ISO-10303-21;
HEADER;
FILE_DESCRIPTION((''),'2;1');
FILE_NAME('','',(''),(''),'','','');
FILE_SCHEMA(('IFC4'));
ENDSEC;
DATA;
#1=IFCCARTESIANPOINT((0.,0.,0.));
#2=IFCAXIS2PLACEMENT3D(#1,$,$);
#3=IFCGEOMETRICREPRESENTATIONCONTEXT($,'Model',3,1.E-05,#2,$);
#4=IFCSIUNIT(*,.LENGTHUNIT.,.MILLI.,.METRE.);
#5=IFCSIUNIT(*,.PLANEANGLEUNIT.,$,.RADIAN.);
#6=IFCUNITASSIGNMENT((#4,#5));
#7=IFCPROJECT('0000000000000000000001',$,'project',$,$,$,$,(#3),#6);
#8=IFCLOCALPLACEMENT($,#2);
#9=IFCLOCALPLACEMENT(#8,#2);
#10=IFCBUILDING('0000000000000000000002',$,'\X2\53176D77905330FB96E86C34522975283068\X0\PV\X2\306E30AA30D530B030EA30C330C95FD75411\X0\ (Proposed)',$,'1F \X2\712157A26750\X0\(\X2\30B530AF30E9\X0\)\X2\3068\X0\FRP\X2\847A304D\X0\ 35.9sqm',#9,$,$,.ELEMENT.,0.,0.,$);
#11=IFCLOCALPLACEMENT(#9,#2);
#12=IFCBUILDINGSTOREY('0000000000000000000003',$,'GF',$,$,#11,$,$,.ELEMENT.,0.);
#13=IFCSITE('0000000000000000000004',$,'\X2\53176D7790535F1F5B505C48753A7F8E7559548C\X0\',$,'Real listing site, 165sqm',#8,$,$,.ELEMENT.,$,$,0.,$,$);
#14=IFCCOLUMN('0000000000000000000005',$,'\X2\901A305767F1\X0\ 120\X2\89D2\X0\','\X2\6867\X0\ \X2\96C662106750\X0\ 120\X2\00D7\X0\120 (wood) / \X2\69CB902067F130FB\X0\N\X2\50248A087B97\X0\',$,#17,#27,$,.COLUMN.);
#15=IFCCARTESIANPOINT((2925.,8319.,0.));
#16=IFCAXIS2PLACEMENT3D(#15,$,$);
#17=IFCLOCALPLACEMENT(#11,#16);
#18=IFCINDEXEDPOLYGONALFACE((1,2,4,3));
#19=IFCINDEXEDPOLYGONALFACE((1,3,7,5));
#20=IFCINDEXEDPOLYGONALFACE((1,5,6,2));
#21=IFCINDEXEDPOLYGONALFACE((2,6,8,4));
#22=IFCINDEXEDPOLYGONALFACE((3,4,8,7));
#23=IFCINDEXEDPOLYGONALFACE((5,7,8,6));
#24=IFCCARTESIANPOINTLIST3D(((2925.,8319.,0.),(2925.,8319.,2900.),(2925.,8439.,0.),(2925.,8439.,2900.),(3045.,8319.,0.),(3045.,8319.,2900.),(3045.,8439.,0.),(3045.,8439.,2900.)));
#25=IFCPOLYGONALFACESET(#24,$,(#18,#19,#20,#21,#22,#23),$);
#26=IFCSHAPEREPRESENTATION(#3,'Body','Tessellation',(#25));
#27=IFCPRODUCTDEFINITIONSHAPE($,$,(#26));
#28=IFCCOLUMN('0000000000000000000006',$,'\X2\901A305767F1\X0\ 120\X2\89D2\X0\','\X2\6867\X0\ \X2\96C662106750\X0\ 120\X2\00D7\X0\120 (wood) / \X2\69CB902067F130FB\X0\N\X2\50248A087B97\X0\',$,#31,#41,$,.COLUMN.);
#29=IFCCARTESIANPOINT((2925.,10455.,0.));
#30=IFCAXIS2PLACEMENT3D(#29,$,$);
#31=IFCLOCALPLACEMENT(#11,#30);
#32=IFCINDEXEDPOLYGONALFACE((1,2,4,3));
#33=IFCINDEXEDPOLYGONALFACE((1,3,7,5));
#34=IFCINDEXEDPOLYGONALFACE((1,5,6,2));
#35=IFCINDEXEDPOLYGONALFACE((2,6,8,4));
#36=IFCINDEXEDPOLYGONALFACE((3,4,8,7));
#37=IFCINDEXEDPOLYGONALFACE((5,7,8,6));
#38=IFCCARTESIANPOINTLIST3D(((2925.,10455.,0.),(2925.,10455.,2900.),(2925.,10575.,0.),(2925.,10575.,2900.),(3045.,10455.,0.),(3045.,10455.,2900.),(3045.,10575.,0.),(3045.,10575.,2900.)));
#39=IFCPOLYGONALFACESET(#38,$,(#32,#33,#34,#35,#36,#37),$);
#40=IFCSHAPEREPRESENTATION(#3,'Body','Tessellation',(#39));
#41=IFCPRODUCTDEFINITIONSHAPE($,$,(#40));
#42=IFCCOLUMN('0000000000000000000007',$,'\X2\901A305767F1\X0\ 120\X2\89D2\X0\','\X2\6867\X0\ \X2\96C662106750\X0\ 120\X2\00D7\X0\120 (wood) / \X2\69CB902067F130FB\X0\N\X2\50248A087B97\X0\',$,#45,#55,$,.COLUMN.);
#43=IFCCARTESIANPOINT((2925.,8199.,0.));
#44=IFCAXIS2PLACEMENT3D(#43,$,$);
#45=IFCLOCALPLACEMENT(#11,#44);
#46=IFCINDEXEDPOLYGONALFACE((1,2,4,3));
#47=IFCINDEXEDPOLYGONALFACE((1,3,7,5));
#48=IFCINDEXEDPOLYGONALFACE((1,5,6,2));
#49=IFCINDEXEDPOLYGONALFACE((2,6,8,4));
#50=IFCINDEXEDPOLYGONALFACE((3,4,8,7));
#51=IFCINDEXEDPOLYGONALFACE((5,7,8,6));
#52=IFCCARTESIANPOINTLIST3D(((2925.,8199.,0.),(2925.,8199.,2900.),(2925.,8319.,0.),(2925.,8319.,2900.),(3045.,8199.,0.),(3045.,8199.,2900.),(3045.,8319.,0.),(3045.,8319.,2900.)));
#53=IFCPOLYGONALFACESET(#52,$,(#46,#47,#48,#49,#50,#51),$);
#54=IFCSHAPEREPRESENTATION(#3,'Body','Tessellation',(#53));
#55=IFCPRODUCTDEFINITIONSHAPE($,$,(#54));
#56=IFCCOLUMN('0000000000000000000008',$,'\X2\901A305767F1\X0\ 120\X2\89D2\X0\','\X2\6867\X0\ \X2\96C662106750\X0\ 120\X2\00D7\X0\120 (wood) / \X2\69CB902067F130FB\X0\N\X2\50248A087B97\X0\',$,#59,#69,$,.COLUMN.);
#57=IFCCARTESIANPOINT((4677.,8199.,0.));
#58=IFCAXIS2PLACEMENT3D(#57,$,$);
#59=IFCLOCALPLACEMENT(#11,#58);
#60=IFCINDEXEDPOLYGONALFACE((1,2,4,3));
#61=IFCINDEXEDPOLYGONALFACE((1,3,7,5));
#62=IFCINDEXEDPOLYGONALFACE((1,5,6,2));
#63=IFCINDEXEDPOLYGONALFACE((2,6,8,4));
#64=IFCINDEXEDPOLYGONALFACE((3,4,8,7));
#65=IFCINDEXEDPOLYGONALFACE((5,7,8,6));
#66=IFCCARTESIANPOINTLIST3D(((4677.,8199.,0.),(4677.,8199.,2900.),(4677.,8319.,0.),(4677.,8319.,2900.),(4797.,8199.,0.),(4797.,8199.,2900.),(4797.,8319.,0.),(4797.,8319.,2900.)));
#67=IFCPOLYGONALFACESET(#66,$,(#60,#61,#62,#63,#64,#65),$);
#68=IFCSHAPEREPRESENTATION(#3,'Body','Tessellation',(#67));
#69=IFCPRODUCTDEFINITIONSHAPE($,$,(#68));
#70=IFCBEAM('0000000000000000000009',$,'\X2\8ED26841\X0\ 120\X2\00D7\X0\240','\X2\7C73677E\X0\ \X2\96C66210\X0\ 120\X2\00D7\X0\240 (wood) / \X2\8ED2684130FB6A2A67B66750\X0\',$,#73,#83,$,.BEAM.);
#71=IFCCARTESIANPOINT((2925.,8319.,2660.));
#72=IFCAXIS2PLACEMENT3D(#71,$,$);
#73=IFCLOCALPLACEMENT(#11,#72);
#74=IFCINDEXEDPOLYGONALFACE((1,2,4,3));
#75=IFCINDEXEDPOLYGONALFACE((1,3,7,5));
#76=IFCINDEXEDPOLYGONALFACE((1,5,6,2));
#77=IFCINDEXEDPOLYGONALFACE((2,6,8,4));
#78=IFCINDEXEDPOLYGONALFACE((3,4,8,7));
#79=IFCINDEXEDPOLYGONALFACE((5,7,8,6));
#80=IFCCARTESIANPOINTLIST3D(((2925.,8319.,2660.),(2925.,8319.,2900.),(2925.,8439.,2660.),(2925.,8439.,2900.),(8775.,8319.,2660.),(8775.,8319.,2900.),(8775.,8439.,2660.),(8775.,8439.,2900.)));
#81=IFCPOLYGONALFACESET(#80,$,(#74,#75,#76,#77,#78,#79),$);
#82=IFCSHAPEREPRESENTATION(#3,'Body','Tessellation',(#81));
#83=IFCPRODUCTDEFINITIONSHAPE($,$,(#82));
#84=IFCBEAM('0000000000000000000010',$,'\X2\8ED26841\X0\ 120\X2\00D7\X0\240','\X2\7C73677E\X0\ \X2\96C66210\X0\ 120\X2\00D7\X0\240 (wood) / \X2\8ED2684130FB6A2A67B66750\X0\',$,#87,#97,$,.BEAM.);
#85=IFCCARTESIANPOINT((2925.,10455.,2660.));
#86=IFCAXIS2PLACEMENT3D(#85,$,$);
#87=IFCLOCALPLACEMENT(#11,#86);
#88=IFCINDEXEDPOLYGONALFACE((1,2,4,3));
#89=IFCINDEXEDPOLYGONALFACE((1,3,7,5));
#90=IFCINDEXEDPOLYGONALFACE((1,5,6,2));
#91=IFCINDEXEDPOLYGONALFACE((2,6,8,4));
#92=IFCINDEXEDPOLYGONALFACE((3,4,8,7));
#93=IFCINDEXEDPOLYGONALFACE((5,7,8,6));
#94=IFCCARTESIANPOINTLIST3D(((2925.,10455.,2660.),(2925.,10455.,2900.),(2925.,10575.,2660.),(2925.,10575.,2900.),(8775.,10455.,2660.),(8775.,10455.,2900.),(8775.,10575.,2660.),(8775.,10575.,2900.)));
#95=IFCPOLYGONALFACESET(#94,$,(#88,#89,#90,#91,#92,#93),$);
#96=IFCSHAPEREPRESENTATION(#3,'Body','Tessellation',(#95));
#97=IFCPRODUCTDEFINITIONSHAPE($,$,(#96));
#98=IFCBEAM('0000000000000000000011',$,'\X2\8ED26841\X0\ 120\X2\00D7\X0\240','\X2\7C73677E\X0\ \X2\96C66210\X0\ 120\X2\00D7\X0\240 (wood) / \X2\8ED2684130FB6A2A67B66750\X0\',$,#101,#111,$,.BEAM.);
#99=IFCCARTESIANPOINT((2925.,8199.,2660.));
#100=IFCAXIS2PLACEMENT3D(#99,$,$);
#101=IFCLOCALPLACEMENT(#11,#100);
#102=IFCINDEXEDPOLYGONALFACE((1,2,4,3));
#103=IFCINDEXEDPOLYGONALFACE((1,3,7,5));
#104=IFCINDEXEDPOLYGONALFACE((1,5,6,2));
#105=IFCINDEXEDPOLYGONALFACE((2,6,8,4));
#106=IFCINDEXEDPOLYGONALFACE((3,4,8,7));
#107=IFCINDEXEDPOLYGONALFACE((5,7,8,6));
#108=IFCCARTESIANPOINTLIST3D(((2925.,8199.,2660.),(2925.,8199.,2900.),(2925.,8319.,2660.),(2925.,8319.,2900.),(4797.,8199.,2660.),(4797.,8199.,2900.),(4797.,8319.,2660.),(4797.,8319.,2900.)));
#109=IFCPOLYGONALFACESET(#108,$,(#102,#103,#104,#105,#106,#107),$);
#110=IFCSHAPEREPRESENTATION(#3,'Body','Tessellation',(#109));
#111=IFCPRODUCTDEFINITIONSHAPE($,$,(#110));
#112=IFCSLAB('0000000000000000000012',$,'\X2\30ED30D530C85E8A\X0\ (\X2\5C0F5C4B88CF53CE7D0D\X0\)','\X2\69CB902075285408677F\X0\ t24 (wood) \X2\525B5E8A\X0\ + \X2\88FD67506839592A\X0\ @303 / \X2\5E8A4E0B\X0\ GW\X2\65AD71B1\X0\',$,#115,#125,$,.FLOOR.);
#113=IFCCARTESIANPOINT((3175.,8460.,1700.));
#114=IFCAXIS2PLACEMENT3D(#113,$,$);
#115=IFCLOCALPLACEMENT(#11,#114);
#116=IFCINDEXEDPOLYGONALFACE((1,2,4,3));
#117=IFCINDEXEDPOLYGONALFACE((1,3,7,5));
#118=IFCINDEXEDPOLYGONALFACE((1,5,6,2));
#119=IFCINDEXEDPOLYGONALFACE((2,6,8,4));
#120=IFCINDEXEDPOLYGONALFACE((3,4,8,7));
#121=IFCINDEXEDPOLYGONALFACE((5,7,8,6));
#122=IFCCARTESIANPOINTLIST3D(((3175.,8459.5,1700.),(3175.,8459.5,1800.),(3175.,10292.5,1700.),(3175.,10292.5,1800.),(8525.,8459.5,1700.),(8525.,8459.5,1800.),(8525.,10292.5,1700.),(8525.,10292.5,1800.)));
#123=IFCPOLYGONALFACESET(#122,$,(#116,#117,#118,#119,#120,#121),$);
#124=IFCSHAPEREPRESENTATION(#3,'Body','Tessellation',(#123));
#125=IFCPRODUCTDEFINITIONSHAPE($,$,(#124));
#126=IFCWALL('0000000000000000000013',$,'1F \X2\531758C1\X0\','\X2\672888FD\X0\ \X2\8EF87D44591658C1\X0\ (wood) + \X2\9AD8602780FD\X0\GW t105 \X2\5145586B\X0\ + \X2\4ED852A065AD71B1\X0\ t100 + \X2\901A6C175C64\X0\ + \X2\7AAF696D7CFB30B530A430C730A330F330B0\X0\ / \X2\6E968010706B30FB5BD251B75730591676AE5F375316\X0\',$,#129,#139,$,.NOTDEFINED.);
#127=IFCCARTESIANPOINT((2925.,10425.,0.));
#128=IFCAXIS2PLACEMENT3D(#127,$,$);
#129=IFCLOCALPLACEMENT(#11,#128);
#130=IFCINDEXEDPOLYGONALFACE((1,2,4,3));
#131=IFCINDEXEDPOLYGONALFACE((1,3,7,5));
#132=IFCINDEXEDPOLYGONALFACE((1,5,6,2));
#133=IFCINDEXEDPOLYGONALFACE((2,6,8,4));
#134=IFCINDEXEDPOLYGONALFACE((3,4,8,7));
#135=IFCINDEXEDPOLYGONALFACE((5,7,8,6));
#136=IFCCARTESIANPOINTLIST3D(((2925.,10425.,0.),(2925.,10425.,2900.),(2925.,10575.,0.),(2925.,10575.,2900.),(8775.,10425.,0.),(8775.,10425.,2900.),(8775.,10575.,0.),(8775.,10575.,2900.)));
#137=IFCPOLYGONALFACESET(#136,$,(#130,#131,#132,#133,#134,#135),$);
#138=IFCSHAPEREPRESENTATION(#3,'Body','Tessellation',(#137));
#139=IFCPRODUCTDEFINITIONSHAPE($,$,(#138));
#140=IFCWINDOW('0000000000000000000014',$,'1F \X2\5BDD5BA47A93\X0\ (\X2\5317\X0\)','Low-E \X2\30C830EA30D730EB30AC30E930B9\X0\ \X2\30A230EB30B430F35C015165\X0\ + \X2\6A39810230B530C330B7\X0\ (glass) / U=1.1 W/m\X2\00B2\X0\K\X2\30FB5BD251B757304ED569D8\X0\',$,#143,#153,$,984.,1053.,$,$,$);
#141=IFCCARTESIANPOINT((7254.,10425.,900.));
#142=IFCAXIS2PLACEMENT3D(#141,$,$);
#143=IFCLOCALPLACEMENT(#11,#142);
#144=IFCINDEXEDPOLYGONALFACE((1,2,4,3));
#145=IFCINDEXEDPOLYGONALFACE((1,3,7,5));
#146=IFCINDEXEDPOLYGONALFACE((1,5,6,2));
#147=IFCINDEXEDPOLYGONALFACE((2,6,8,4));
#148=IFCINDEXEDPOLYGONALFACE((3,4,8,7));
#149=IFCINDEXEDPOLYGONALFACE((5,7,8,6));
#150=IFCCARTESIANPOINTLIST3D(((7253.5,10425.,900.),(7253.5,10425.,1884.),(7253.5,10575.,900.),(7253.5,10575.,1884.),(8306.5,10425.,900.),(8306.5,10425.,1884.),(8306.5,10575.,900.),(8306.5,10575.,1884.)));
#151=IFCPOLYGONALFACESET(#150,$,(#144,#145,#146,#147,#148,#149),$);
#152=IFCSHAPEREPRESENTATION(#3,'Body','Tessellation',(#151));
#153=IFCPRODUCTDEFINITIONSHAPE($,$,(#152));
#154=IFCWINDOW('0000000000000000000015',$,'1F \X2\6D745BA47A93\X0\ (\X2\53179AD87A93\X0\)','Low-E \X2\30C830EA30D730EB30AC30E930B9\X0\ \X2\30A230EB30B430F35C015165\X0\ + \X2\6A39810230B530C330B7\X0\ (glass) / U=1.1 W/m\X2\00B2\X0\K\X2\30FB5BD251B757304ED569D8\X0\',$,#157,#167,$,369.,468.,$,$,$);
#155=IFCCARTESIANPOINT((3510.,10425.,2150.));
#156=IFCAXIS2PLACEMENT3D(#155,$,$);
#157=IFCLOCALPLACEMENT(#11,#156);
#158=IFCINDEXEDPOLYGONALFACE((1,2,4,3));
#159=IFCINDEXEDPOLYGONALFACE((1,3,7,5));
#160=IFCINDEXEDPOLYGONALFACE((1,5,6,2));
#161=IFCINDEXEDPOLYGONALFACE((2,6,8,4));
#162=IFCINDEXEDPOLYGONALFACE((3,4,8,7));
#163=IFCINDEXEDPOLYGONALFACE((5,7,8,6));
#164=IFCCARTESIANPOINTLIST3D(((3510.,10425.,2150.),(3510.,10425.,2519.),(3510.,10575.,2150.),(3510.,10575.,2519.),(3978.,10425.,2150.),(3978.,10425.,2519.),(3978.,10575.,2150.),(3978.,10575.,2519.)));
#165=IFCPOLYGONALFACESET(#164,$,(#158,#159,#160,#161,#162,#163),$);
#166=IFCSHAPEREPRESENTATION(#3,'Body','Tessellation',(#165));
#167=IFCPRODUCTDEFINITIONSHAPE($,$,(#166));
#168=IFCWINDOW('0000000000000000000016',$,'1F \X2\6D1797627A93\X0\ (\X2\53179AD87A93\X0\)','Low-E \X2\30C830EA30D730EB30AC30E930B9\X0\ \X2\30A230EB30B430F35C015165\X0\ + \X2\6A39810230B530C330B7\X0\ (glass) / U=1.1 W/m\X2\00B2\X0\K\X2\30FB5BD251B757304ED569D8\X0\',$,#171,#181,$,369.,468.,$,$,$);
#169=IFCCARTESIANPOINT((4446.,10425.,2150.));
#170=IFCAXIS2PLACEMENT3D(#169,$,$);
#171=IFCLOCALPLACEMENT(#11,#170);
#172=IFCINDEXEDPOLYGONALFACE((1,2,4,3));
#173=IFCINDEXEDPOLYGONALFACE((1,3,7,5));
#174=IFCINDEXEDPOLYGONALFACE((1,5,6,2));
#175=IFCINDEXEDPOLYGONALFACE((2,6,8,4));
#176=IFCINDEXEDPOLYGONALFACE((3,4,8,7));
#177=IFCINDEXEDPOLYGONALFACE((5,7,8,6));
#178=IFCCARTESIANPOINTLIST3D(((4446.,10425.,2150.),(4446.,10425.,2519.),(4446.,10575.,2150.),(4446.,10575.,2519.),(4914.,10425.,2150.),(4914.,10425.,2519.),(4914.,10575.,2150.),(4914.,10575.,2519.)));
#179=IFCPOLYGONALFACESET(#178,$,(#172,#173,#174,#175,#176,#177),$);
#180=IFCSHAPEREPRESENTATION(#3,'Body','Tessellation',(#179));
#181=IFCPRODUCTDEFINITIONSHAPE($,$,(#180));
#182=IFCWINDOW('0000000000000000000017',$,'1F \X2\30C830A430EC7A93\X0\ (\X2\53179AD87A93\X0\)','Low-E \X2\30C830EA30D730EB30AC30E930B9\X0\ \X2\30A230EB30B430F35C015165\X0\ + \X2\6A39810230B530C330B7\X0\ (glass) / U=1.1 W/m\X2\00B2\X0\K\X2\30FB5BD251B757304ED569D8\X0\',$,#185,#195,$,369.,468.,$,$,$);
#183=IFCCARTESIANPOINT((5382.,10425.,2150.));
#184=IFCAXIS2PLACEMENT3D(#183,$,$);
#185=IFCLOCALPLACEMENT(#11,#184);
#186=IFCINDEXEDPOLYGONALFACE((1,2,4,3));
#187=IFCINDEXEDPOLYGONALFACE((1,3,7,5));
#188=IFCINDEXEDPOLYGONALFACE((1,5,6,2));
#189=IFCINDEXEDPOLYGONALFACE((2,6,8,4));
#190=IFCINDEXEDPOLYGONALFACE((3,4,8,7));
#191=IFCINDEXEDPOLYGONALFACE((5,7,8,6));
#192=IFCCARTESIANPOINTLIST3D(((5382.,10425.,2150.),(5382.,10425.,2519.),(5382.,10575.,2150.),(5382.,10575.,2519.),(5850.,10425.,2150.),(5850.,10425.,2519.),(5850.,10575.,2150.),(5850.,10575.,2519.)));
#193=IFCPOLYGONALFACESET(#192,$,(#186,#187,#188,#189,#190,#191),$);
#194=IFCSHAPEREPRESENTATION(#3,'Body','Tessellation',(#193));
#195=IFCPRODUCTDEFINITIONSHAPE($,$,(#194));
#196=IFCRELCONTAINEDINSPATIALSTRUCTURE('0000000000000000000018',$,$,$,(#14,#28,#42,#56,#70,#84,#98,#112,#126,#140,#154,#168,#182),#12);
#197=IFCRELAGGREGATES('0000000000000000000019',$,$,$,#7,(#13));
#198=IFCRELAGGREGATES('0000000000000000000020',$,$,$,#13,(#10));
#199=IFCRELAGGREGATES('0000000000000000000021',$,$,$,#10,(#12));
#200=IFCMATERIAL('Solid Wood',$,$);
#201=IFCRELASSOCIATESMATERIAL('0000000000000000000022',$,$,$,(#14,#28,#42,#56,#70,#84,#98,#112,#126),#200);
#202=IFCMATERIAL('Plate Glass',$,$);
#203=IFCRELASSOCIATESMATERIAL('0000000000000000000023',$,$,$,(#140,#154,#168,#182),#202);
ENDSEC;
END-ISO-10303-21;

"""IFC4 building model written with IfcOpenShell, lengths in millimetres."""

from ifc_helpers import new_model, si_unit, frame, frame_2d, origin, place, context, project, spatial, rectangle, extrude, material, element, fill, save


model = new_model("IFC4")

# Units and contexts
model_context = context("Model", 3, precision=1e-05, world=origin())
ifc_project = project(units=[si_unit("LENGTHUNIT", "METRE", prefix="MILLI"), si_unit("PLANEANGLEUNIT", "RADIAN")], contexts=[model_context])

# Site, building, storey
site_placement = place(None, origin())
site = spatial("IfcSite", under=ifc_project, at=site_placement, Name="北海道弟子屈町美留和", ObjectType="Real listing site, 165sqm", CompositionType="ELEMENT", RefElevation=0.0)
building_placement = place(site_placement, origin())
building = spatial("IfcBuilding", under=site, at=building_placement, Name="北海道・雨水利用とPVのオフグリッド志向 (Proposed)", ObjectType="1F 無垢材(サクラ)とFRP葺き 35.9sqm", CompositionType="ELEMENT", ElevationOfRefHeight=0.0, ElevationOfTerrain=0.0)
storey_placement = place(building_placement, origin())
storey = spatial("IfcBuildingStorey", under=building, at=storey_placement, Name="GF", CompositionType="ELEMENT", Elevation=0.0)

# Columns
ifc_material_1 = material(Name="Solid Wood")
column_1_placement = place(storey_placement, frame((2925.0, 8319.0, 0.0)))
element("IfcColumn", 1, at=column_1_placement, inside=storey, material=ifc_material_1, Name="通し柱 120角", Description="桧 集成材 120×120 (wood) / 構造柱・N値計算", PredefinedType="COLUMN", context=model_context, shape_type="SweptSolid", body=[
    extrude(rectangle(XDim=120.0, YDim=120.0, at=frame_2d((60.0, 60.0))), frame((2925.0, 8319.0, 0.0)), (0.0, 0.0, 1.0), 2900.0),
])
column_2_placement = place(storey_placement, frame((2925.0, 10455.0, 0.0)))
element("IfcColumn", 2, at=column_2_placement, inside=storey, material=ifc_material_1, Name="通し柱 120角", Description="桧 集成材 120×120 (wood) / 構造柱・N値計算", PredefinedType="COLUMN", context=model_context, shape_type="SweptSolid", body=[
    extrude(rectangle(XDim=120.0, YDim=120.0, at=frame_2d((60.0, 60.0))), frame((2925.0, 10455.0, 0.0)), (0.0, 0.0, 1.0), 2900.0),
])
column_3_placement = place(storey_placement, frame((2925.0, 8199.0, 0.0)))
element("IfcColumn", 3, at=column_3_placement, inside=storey, material=ifc_material_1, Name="通し柱 120角", Description="桧 集成材 120×120 (wood) / 構造柱・N値計算", PredefinedType="COLUMN", context=model_context, shape_type="SweptSolid", body=[
    extrude(rectangle(XDim=120.0, YDim=120.0, at=frame_2d((60.0, 60.0))), frame((2925.0, 8199.0, 0.0)), (0.0, 0.0, 1.0), 2900.0),
])
column_4_placement = place(storey_placement, frame((4677.0, 8199.0, 0.0)))
element("IfcColumn", 4, at=column_4_placement, inside=storey, material=ifc_material_1, Name="通し柱 120角", Description="桧 集成材 120×120 (wood) / 構造柱・N値計算", PredefinedType="COLUMN", context=model_context, shape_type="SweptSolid", body=[
    extrude(rectangle(XDim=120.0, YDim=120.0, at=frame_2d((60.0, 60.0))), frame((4677.0, 8199.0, 0.0)), (0.0, 0.0, 1.0), 2900.0),
])

# Beams
beam_1_placement = place(storey_placement, frame((2925.0, 8319.0, 2660.0)))
element("IfcBeam", 5, at=beam_1_placement, inside=storey, material=ifc_material_1, Name="軒桁 120×240", Description="米松 集成 120×240 (wood) / 軒桁・横架材", PredefinedType="BEAM", context=model_context, shape_type="SweptSolid", body=[
    extrude(rectangle(XDim=5850.0, YDim=120.0, at=frame_2d((2925.0, 60.0))), frame((2925.0, 8319.0, 2660.0)), (0.0, 0.0, 1.0), 240.0),
])
beam_2_placement = place(storey_placement, frame((2925.0, 10455.0, 2660.0)))
element("IfcBeam", 6, at=beam_2_placement, inside=storey, material=ifc_material_1, Name="軒桁 120×240", Description="米松 集成 120×240 (wood) / 軒桁・横架材", PredefinedType="BEAM", context=model_context, shape_type="SweptSolid", body=[
    extrude(rectangle(XDim=5850.0, YDim=120.0, at=frame_2d((2925.0, 60.0))), frame((2925.0, 10455.0, 2660.0)), (0.0, 0.0, 1.0), 240.0),
])
beam_3_placement = place(storey_placement, frame((2925.0, 8199.0, 2660.0)))
element("IfcBeam", 7, at=beam_3_placement, inside=storey, material=ifc_material_1, Name="軒桁 120×240", Description="米松 集成 120×240 (wood) / 軒桁・横架材", PredefinedType="BEAM", context=model_context, shape_type="SweptSolid", body=[
    extrude(rectangle(XDim=1872.0, YDim=120.0, at=frame_2d((936.0, 60.0))), frame((2925.0, 8199.0, 2660.0)), (0.0, 0.0, 1.0), 240.0),
])

# Slab
slab_1_placement = place(storey_placement, frame((3175.0, 8460.0, 1700.0)))
element("IfcSlab", 8, at=slab_1_placement, inside=storey, material=ifc_material_1, Name="ロフト床 (小屋裏収納)", Description="構造用合板 t24 (wood) 剛床 + 製材根太 @303 / 床下 GW断熱", PredefinedType="FLOOR", context=model_context, shape_type="SweptSolid", body=[
    extrude(rectangle(XDim=5350.0, YDim=1833.0, at=frame_2d((2675.0, 916.0))), frame((3175.0, 8460.0, 1700.0)), (0.0, 0.0, 1.0), 100.0),
])

# Wall, openings, windows
wall_1_placement = place(storey_placement, frame((2925.0, 10425.0, 0.0)))
wall_1 = element("IfcWall", 9, at=wall_1_placement, inside=storey, material=ifc_material_1, Name="1F 北壁", Description="木製 軸組外壁 (wood) + 高性能GW t105 充填 + 付加断熱 t100 + 通気層 + 窯業系サイディング / 準耐火・寒冷地外皮強化", PredefinedType="NOTDEFINED", context=model_context, shape_type="SweptSolid", body=[
    extrude(rectangle(XDim=5850.0, YDim=150.0, at=frame_2d((2925.0, 75.0))), frame((2925.0, 10425.0, 0.0)), (0.0, 0.0, 1.0), 2900.0),
])
opening_1_placement = place(storey_placement, frame((7254.0, 10425.0, 900.0)))
opening_1 = element("IfcOpeningElement", 10, at=opening_1_placement, cuts=wall_1, PredefinedType="NOTDEFINED", context=model_context, shape_type="SweptSolid", body=[
    extrude(rectangle(XDim=1053.0, YDim=150.0, at=frame_2d((526.0, 75.0))), frame((7254.0, 10425.0, 900.0)), (0.0, 0.0, 1.0), 984.0),
])
opening_2_placement = place(storey_placement, frame((3510.0, 10425.0, 2150.0)))
opening_2 = element("IfcOpeningElement", 11, at=opening_2_placement, cuts=wall_1, PredefinedType="NOTDEFINED", context=model_context, shape_type="SweptSolid", body=[
    extrude(rectangle(XDim=468.0, YDim=150.0, at=frame_2d((234.0, 75.0))), frame((3510.0, 10425.0, 2150.0)), (0.0, 0.0, 1.0), 369.0),
])
opening_3_placement = place(storey_placement, frame((4446.0, 10425.0, 2150.0)))
opening_3 = element("IfcOpeningElement", 12, at=opening_3_placement, cuts=wall_1, PredefinedType="NOTDEFINED", context=model_context, shape_type="SweptSolid", body=[
    extrude(rectangle(XDim=468.0, YDim=150.0, at=frame_2d((234.0, 75.0))), frame((4446.0, 10425.0, 2150.0)), (0.0, 0.0, 1.0), 369.0),
])
opening_4_placement = place(storey_placement, frame((5382.0, 10425.0, 2150.0)))
opening_4 = element("IfcOpeningElement", 13, at=opening_4_placement, cuts=wall_1, PredefinedType="NOTDEFINED", context=model_context, shape_type="SweptSolid", body=[
    extrude(rectangle(XDim=468.0, YDim=150.0, at=frame_2d((234.0, 75.0))), frame((5382.0, 10425.0, 2150.0)), (0.0, 0.0, 1.0), 369.0),
])
ifc_material_2 = material(Name="Plate Glass")
window_1_placement = place(storey_placement, frame((7254.0, 10425.0, 900.0)))
window_1 = element("IfcWindow", 14, at=window_1_placement, inside=storey, material=ifc_material_2, Name="1F 寝室窓 (北)", Description="Low-E トリプルガラス アルゴン封入 + 樹脂サッシ (glass) / U=1.1 W/m²K・寒冷地仕様", OverallHeight=984.0, OverallWidth=1053.0, context=model_context, shape_type="SweptSolid", body=[
    extrude(rectangle(XDim=1053.0, YDim=150.0, at=frame_2d((526.0, 75.0))), frame((7254.0, 10425.0, 900.0)), (0.0, 0.0, 1.0), 984.0),
])
fill(opening_1, window_1)
window_2_placement = place(storey_placement, frame((3510.0, 10425.0, 2150.0)))
window_2 = element("IfcWindow", 15, at=window_2_placement, inside=storey, material=ifc_material_2, Name="1F 浴室窓 (北高窓)", Description="Low-E トリプルガラス アルゴン封入 + 樹脂サッシ (glass) / U=1.1 W/m²K・寒冷地仕様", OverallHeight=369.0, OverallWidth=468.0, context=model_context, shape_type="SweptSolid", body=[
    extrude(rectangle(XDim=468.0, YDim=150.0, at=frame_2d((234.0, 75.0))), frame((3510.0, 10425.0, 2150.0)), (0.0, 0.0, 1.0), 369.0),
])
fill(opening_2, window_2)
window_3_placement = place(storey_placement, frame((4446.0, 10425.0, 2150.0)))
window_3 = element("IfcWindow", 16, at=window_3_placement, inside=storey, material=ifc_material_2, Name="1F 洗面窓 (北高窓)", Description="Low-E トリプルガラス アルゴン封入 + 樹脂サッシ (glass) / U=1.1 W/m²K・寒冷地仕様", OverallHeight=369.0, OverallWidth=468.0, context=model_context, shape_type="SweptSolid", body=[
    extrude(rectangle(XDim=468.0, YDim=150.0, at=frame_2d((234.0, 75.0))), frame((4446.0, 10425.0, 2150.0)), (0.0, 0.0, 1.0), 369.0),
])
fill(opening_3, window_3)
window_4_placement = place(storey_placement, frame((5382.0, 10425.0, 2150.0)))
window_4 = element("IfcWindow", 17, at=window_4_placement, inside=storey, material=ifc_material_2, Name="1F トイレ窓 (北高窓)", Description="Low-E トリプルガラス アルゴン封入 + 樹脂サッシ (glass) / U=1.1 W/m²K・寒冷地仕様", OverallHeight=369.0, OverallWidth=468.0, context=model_context, shape_type="SweptSolid", body=[
    extrude(rectangle(XDim=468.0, YDim=150.0, at=frame_2d((234.0, 75.0))), frame((5382.0, 10425.0, 2150.0)), (0.0, 0.0, 1.0), 369.0),
])
fill(opening_4, window_4)

save(model, "model.ifc")
